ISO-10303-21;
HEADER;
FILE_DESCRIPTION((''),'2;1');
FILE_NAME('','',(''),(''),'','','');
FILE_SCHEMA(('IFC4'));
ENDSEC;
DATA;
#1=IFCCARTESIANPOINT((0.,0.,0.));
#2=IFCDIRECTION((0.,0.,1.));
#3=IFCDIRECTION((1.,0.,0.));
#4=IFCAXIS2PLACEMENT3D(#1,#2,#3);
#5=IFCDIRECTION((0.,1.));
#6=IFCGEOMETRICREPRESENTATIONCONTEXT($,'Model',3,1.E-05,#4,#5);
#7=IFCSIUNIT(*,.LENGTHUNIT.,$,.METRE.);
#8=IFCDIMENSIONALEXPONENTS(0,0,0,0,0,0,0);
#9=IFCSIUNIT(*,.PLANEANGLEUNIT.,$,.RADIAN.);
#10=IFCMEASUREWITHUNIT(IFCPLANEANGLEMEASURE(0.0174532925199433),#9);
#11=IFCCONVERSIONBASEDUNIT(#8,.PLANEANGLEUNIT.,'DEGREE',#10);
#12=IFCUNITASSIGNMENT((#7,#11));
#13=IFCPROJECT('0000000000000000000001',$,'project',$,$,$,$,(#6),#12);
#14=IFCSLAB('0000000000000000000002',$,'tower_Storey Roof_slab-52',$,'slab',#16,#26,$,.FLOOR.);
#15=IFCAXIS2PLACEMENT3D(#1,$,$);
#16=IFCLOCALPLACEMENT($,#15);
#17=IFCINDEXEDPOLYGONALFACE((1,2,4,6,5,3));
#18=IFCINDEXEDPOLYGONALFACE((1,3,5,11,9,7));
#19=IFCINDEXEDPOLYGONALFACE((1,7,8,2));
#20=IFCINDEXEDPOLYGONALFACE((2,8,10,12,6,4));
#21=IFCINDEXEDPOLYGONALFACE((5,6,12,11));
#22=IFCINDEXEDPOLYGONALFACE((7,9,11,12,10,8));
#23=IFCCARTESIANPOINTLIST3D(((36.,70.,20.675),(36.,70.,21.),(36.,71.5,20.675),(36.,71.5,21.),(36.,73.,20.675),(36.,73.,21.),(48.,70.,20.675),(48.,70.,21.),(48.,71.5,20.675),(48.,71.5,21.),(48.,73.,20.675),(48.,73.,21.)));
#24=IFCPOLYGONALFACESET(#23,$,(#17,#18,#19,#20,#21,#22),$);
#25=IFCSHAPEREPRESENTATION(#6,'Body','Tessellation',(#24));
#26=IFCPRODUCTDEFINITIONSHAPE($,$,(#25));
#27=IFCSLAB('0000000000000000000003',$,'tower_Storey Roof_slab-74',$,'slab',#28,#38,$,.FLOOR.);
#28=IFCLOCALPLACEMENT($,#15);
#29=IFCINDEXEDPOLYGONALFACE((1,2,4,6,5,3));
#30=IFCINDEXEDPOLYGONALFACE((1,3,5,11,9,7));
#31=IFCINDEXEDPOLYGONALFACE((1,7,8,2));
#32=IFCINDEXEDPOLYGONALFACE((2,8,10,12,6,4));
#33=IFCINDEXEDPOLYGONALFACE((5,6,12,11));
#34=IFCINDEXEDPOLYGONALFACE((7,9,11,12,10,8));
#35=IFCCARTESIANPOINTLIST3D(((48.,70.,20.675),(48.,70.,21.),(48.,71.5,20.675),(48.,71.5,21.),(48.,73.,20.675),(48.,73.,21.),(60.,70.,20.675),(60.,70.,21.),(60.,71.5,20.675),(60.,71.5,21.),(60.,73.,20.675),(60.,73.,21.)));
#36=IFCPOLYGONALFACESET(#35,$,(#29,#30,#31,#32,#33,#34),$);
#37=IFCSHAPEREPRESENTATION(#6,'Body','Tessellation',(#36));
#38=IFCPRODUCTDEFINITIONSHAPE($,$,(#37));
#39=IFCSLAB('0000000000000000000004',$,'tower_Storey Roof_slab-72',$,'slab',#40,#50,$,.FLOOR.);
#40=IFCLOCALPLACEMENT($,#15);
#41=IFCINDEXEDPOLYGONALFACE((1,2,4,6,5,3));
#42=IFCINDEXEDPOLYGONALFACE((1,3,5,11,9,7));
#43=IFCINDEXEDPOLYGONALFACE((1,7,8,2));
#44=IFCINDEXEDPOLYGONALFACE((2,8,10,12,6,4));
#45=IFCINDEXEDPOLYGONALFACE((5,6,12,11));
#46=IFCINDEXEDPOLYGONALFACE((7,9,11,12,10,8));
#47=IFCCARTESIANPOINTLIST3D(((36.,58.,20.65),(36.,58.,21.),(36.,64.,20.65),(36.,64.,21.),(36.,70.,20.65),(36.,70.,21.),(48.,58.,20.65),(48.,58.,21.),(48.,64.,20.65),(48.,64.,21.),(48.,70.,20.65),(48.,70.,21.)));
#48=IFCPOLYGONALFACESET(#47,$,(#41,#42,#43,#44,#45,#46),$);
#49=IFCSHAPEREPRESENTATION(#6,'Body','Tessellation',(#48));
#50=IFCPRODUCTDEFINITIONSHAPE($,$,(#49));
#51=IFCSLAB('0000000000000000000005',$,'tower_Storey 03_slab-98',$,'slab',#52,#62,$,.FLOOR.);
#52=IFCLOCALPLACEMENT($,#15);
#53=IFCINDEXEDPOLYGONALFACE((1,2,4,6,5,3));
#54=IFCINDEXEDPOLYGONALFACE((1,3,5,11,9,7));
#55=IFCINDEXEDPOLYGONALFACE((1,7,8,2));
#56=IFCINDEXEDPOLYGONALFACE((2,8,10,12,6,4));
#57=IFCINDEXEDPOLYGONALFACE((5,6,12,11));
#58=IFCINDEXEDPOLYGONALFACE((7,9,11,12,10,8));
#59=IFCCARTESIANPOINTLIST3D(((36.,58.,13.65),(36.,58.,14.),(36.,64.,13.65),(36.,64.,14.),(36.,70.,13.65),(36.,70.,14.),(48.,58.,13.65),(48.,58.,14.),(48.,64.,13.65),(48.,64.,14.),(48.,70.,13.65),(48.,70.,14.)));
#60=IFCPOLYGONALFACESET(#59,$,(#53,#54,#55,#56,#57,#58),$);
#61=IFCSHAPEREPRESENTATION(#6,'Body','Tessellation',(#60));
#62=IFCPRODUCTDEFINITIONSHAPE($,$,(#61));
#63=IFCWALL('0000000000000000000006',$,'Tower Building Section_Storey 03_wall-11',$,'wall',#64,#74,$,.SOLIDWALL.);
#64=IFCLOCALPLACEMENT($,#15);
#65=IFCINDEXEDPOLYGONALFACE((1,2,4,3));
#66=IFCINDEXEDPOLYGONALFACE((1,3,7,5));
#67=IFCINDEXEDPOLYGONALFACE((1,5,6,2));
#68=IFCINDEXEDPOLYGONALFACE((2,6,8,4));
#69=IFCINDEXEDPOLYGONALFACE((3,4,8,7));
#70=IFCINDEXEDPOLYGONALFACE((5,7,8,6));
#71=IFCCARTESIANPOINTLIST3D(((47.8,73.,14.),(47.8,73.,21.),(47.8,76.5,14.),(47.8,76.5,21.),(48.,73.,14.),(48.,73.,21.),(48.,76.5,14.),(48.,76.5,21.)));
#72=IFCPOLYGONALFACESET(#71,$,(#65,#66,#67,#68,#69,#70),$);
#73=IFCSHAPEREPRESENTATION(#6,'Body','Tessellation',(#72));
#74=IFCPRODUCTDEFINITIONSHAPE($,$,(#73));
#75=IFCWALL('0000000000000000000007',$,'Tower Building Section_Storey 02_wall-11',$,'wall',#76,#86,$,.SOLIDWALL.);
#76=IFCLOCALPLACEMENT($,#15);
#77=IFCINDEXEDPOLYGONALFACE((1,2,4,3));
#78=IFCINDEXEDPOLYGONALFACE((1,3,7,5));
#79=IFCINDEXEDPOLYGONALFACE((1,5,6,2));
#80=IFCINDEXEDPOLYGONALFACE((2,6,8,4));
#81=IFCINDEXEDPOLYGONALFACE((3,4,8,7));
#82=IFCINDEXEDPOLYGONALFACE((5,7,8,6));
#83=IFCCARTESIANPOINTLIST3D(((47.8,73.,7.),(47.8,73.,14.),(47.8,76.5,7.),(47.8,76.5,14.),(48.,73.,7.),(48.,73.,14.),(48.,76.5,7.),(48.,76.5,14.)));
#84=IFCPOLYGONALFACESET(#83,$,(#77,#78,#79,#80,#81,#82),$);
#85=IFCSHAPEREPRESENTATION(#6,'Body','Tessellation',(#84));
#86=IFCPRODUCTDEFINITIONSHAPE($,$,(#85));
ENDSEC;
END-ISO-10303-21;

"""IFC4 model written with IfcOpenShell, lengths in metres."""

from ifc_helpers import new_model, entity, si_unit, converted_unit, direction, frame, origin_with_axes, place, context, project, polyline, outline, extrude, element, save


model = new_model("IFC4")

# Units and contexts
model_context = context("Model", 3, precision=1e-05, world=origin_with_axes(), true_north=direction((0.0, 1.0)))
ifc_project = project(units=[si_unit("LENGTHUNIT", "METRE"), converted_unit("PLANEANGLEUNIT", "DEGREE", entity("IfcPlaneAngleMeasure", 0.0174532925199433), si_unit("PLANEANGLEUNIT", "RADIAN"), dimensions=[0, 0, 0, 0, 0, 0, 0])], contexts=[model_context])

# Shared definitions
placement_1 = place(None, origin_with_axes())
placement_2 = place(placement_1, frame((0.0, 0.0, 14.0), z_axis=(0.0, 0.0, 1.0), x_axis=(1.0, 0.0, 0.0)))
placement_3 = place(placement_1, frame((0.0, 0.0, 7.0), z_axis=(0.0, 0.0, 1.0), x_axis=(1.0, 0.0, 0.0)))

# Shared definitions
placement_4 = place(placement_1, frame((0.0, 0.0, 21.0), z_axis=(0.0, 0.0, 1.0), x_axis=(1.0, 0.0, 0.0)))

# Slabs
for number, where, z_axis, x_axis, name in (
    (1, (42.0, 71.5, -0.325), (0.0, 0.0, 1.0), (1.0, 0.0, 0.0), "tower_Storey Roof_slab-52"),
    (2, (54.0, 71.5, -0.325), (0.0, 0.0, 1.0), (1.0, 0.0, 0.0), "tower_Storey Roof_slab-74"),
):
    element("IfcSlab", number, at=place(placement_4, frame(where, z_axis=z_axis, x_axis=x_axis)), Name=name, ObjectType="slab", PredefinedType="FLOOR", context=model_context, body=[
        extrude(outline(polyline([(-6.0, -1.5, 0.0), (6.0, -1.5, 0.0), (6.0, 0.0, 0.0), (6.0, 1.5, 0.0), (-6.0, 1.5, 0.0), (-6.0, 0.0, 0.0), (-6.0, -1.5, 0.0)])), origin_with_axes(), (0.0, 0.0, 1.0), 0.325),
    ])
slab_1_placement = place(placement_4, frame((42.0, 64.0, -0.35), z_axis=(0.0, 0.0, 1.0), x_axis=(1.0, 0.0, 0.0)))
element("IfcSlab", 3, at=slab_1_placement, Name="tower_Storey Roof_slab-72", ObjectType="slab", PredefinedType="FLOOR", context=model_context, body=[
    extrude(outline(polyline([(-6.0, -6.0, 0.0), (6.0, -6.0, 0.0), (6.0, 0.0, 0.0), (6.0, 6.0, 0.0), (-6.0, 6.0, 0.0), (-6.0, 0.0, 0.0), (-6.0, -6.0, 0.0)])), origin_with_axes(), (0.0, 0.0, 1.0), 0.35),
])
slab_2_placement = place(placement_2, frame((42.0, 64.0, -0.35), z_axis=(0.0, 0.0, 1.0), x_axis=(1.0, 0.0, 0.0)))
element("IfcSlab", 4, at=slab_2_placement, Name="tower_Storey 03_slab-98", ObjectType="slab", PredefinedType="FLOOR", context=model_context, body=[
    extrude(outline(polyline([(-6.0, -6.0, 0.0), (6.0, -6.0, 0.0), (6.0, 0.0, 0.0), (6.0, 6.0, 0.0), (-6.0, 6.0, 0.0), (-6.0, 0.0, 0.0), (-6.0, -6.0, 0.0)])), origin_with_axes(), (0.0, 0.0, 1.0), 0.35),
])

# Walls
wall_1_placement = place(placement_2, frame((48.0, 74.75, 3.5), z_axis=(-1.0, 0.0, 0.0), x_axis=(0.0, 0.0, 1.0)))
element("IfcWall", 5, at=wall_1_placement, Name="Tower Building Section_Storey 03_wall-11", ObjectType="wall", PredefinedType="SOLIDWALL", context=model_context, body=[
    extrude(outline(polyline([(-3.5, -1.75, 0.0), (3.5, -1.75, 0.0), (3.5, 1.75, 0.0), (-3.5, 1.75, 0.0), (-3.5, -1.75, 0.0)])), origin_with_axes(), (0.0, 0.0, 1.0), 0.2),
])
wall_2_placement = place(placement_3, frame((48.0, 74.75, 3.5), z_axis=(-1.0, 0.0, 0.0), x_axis=(0.0, 0.0, 1.0)))
element("IfcWall", 6, at=wall_2_placement, Name="Tower Building Section_Storey 02_wall-11", ObjectType="wall", PredefinedType="SOLIDWALL", context=model_context, body=[
    extrude(outline(polyline([(-3.5, -1.75, 0.0), (3.5, -1.75, 0.0), (3.5, 1.75, 0.0), (-3.5, 1.75, 0.0), (-3.5, -1.75, 0.0)])), origin_with_axes(), (0.0, 0.0, 1.0), 0.2),
])

save(model, "model.ifc")
